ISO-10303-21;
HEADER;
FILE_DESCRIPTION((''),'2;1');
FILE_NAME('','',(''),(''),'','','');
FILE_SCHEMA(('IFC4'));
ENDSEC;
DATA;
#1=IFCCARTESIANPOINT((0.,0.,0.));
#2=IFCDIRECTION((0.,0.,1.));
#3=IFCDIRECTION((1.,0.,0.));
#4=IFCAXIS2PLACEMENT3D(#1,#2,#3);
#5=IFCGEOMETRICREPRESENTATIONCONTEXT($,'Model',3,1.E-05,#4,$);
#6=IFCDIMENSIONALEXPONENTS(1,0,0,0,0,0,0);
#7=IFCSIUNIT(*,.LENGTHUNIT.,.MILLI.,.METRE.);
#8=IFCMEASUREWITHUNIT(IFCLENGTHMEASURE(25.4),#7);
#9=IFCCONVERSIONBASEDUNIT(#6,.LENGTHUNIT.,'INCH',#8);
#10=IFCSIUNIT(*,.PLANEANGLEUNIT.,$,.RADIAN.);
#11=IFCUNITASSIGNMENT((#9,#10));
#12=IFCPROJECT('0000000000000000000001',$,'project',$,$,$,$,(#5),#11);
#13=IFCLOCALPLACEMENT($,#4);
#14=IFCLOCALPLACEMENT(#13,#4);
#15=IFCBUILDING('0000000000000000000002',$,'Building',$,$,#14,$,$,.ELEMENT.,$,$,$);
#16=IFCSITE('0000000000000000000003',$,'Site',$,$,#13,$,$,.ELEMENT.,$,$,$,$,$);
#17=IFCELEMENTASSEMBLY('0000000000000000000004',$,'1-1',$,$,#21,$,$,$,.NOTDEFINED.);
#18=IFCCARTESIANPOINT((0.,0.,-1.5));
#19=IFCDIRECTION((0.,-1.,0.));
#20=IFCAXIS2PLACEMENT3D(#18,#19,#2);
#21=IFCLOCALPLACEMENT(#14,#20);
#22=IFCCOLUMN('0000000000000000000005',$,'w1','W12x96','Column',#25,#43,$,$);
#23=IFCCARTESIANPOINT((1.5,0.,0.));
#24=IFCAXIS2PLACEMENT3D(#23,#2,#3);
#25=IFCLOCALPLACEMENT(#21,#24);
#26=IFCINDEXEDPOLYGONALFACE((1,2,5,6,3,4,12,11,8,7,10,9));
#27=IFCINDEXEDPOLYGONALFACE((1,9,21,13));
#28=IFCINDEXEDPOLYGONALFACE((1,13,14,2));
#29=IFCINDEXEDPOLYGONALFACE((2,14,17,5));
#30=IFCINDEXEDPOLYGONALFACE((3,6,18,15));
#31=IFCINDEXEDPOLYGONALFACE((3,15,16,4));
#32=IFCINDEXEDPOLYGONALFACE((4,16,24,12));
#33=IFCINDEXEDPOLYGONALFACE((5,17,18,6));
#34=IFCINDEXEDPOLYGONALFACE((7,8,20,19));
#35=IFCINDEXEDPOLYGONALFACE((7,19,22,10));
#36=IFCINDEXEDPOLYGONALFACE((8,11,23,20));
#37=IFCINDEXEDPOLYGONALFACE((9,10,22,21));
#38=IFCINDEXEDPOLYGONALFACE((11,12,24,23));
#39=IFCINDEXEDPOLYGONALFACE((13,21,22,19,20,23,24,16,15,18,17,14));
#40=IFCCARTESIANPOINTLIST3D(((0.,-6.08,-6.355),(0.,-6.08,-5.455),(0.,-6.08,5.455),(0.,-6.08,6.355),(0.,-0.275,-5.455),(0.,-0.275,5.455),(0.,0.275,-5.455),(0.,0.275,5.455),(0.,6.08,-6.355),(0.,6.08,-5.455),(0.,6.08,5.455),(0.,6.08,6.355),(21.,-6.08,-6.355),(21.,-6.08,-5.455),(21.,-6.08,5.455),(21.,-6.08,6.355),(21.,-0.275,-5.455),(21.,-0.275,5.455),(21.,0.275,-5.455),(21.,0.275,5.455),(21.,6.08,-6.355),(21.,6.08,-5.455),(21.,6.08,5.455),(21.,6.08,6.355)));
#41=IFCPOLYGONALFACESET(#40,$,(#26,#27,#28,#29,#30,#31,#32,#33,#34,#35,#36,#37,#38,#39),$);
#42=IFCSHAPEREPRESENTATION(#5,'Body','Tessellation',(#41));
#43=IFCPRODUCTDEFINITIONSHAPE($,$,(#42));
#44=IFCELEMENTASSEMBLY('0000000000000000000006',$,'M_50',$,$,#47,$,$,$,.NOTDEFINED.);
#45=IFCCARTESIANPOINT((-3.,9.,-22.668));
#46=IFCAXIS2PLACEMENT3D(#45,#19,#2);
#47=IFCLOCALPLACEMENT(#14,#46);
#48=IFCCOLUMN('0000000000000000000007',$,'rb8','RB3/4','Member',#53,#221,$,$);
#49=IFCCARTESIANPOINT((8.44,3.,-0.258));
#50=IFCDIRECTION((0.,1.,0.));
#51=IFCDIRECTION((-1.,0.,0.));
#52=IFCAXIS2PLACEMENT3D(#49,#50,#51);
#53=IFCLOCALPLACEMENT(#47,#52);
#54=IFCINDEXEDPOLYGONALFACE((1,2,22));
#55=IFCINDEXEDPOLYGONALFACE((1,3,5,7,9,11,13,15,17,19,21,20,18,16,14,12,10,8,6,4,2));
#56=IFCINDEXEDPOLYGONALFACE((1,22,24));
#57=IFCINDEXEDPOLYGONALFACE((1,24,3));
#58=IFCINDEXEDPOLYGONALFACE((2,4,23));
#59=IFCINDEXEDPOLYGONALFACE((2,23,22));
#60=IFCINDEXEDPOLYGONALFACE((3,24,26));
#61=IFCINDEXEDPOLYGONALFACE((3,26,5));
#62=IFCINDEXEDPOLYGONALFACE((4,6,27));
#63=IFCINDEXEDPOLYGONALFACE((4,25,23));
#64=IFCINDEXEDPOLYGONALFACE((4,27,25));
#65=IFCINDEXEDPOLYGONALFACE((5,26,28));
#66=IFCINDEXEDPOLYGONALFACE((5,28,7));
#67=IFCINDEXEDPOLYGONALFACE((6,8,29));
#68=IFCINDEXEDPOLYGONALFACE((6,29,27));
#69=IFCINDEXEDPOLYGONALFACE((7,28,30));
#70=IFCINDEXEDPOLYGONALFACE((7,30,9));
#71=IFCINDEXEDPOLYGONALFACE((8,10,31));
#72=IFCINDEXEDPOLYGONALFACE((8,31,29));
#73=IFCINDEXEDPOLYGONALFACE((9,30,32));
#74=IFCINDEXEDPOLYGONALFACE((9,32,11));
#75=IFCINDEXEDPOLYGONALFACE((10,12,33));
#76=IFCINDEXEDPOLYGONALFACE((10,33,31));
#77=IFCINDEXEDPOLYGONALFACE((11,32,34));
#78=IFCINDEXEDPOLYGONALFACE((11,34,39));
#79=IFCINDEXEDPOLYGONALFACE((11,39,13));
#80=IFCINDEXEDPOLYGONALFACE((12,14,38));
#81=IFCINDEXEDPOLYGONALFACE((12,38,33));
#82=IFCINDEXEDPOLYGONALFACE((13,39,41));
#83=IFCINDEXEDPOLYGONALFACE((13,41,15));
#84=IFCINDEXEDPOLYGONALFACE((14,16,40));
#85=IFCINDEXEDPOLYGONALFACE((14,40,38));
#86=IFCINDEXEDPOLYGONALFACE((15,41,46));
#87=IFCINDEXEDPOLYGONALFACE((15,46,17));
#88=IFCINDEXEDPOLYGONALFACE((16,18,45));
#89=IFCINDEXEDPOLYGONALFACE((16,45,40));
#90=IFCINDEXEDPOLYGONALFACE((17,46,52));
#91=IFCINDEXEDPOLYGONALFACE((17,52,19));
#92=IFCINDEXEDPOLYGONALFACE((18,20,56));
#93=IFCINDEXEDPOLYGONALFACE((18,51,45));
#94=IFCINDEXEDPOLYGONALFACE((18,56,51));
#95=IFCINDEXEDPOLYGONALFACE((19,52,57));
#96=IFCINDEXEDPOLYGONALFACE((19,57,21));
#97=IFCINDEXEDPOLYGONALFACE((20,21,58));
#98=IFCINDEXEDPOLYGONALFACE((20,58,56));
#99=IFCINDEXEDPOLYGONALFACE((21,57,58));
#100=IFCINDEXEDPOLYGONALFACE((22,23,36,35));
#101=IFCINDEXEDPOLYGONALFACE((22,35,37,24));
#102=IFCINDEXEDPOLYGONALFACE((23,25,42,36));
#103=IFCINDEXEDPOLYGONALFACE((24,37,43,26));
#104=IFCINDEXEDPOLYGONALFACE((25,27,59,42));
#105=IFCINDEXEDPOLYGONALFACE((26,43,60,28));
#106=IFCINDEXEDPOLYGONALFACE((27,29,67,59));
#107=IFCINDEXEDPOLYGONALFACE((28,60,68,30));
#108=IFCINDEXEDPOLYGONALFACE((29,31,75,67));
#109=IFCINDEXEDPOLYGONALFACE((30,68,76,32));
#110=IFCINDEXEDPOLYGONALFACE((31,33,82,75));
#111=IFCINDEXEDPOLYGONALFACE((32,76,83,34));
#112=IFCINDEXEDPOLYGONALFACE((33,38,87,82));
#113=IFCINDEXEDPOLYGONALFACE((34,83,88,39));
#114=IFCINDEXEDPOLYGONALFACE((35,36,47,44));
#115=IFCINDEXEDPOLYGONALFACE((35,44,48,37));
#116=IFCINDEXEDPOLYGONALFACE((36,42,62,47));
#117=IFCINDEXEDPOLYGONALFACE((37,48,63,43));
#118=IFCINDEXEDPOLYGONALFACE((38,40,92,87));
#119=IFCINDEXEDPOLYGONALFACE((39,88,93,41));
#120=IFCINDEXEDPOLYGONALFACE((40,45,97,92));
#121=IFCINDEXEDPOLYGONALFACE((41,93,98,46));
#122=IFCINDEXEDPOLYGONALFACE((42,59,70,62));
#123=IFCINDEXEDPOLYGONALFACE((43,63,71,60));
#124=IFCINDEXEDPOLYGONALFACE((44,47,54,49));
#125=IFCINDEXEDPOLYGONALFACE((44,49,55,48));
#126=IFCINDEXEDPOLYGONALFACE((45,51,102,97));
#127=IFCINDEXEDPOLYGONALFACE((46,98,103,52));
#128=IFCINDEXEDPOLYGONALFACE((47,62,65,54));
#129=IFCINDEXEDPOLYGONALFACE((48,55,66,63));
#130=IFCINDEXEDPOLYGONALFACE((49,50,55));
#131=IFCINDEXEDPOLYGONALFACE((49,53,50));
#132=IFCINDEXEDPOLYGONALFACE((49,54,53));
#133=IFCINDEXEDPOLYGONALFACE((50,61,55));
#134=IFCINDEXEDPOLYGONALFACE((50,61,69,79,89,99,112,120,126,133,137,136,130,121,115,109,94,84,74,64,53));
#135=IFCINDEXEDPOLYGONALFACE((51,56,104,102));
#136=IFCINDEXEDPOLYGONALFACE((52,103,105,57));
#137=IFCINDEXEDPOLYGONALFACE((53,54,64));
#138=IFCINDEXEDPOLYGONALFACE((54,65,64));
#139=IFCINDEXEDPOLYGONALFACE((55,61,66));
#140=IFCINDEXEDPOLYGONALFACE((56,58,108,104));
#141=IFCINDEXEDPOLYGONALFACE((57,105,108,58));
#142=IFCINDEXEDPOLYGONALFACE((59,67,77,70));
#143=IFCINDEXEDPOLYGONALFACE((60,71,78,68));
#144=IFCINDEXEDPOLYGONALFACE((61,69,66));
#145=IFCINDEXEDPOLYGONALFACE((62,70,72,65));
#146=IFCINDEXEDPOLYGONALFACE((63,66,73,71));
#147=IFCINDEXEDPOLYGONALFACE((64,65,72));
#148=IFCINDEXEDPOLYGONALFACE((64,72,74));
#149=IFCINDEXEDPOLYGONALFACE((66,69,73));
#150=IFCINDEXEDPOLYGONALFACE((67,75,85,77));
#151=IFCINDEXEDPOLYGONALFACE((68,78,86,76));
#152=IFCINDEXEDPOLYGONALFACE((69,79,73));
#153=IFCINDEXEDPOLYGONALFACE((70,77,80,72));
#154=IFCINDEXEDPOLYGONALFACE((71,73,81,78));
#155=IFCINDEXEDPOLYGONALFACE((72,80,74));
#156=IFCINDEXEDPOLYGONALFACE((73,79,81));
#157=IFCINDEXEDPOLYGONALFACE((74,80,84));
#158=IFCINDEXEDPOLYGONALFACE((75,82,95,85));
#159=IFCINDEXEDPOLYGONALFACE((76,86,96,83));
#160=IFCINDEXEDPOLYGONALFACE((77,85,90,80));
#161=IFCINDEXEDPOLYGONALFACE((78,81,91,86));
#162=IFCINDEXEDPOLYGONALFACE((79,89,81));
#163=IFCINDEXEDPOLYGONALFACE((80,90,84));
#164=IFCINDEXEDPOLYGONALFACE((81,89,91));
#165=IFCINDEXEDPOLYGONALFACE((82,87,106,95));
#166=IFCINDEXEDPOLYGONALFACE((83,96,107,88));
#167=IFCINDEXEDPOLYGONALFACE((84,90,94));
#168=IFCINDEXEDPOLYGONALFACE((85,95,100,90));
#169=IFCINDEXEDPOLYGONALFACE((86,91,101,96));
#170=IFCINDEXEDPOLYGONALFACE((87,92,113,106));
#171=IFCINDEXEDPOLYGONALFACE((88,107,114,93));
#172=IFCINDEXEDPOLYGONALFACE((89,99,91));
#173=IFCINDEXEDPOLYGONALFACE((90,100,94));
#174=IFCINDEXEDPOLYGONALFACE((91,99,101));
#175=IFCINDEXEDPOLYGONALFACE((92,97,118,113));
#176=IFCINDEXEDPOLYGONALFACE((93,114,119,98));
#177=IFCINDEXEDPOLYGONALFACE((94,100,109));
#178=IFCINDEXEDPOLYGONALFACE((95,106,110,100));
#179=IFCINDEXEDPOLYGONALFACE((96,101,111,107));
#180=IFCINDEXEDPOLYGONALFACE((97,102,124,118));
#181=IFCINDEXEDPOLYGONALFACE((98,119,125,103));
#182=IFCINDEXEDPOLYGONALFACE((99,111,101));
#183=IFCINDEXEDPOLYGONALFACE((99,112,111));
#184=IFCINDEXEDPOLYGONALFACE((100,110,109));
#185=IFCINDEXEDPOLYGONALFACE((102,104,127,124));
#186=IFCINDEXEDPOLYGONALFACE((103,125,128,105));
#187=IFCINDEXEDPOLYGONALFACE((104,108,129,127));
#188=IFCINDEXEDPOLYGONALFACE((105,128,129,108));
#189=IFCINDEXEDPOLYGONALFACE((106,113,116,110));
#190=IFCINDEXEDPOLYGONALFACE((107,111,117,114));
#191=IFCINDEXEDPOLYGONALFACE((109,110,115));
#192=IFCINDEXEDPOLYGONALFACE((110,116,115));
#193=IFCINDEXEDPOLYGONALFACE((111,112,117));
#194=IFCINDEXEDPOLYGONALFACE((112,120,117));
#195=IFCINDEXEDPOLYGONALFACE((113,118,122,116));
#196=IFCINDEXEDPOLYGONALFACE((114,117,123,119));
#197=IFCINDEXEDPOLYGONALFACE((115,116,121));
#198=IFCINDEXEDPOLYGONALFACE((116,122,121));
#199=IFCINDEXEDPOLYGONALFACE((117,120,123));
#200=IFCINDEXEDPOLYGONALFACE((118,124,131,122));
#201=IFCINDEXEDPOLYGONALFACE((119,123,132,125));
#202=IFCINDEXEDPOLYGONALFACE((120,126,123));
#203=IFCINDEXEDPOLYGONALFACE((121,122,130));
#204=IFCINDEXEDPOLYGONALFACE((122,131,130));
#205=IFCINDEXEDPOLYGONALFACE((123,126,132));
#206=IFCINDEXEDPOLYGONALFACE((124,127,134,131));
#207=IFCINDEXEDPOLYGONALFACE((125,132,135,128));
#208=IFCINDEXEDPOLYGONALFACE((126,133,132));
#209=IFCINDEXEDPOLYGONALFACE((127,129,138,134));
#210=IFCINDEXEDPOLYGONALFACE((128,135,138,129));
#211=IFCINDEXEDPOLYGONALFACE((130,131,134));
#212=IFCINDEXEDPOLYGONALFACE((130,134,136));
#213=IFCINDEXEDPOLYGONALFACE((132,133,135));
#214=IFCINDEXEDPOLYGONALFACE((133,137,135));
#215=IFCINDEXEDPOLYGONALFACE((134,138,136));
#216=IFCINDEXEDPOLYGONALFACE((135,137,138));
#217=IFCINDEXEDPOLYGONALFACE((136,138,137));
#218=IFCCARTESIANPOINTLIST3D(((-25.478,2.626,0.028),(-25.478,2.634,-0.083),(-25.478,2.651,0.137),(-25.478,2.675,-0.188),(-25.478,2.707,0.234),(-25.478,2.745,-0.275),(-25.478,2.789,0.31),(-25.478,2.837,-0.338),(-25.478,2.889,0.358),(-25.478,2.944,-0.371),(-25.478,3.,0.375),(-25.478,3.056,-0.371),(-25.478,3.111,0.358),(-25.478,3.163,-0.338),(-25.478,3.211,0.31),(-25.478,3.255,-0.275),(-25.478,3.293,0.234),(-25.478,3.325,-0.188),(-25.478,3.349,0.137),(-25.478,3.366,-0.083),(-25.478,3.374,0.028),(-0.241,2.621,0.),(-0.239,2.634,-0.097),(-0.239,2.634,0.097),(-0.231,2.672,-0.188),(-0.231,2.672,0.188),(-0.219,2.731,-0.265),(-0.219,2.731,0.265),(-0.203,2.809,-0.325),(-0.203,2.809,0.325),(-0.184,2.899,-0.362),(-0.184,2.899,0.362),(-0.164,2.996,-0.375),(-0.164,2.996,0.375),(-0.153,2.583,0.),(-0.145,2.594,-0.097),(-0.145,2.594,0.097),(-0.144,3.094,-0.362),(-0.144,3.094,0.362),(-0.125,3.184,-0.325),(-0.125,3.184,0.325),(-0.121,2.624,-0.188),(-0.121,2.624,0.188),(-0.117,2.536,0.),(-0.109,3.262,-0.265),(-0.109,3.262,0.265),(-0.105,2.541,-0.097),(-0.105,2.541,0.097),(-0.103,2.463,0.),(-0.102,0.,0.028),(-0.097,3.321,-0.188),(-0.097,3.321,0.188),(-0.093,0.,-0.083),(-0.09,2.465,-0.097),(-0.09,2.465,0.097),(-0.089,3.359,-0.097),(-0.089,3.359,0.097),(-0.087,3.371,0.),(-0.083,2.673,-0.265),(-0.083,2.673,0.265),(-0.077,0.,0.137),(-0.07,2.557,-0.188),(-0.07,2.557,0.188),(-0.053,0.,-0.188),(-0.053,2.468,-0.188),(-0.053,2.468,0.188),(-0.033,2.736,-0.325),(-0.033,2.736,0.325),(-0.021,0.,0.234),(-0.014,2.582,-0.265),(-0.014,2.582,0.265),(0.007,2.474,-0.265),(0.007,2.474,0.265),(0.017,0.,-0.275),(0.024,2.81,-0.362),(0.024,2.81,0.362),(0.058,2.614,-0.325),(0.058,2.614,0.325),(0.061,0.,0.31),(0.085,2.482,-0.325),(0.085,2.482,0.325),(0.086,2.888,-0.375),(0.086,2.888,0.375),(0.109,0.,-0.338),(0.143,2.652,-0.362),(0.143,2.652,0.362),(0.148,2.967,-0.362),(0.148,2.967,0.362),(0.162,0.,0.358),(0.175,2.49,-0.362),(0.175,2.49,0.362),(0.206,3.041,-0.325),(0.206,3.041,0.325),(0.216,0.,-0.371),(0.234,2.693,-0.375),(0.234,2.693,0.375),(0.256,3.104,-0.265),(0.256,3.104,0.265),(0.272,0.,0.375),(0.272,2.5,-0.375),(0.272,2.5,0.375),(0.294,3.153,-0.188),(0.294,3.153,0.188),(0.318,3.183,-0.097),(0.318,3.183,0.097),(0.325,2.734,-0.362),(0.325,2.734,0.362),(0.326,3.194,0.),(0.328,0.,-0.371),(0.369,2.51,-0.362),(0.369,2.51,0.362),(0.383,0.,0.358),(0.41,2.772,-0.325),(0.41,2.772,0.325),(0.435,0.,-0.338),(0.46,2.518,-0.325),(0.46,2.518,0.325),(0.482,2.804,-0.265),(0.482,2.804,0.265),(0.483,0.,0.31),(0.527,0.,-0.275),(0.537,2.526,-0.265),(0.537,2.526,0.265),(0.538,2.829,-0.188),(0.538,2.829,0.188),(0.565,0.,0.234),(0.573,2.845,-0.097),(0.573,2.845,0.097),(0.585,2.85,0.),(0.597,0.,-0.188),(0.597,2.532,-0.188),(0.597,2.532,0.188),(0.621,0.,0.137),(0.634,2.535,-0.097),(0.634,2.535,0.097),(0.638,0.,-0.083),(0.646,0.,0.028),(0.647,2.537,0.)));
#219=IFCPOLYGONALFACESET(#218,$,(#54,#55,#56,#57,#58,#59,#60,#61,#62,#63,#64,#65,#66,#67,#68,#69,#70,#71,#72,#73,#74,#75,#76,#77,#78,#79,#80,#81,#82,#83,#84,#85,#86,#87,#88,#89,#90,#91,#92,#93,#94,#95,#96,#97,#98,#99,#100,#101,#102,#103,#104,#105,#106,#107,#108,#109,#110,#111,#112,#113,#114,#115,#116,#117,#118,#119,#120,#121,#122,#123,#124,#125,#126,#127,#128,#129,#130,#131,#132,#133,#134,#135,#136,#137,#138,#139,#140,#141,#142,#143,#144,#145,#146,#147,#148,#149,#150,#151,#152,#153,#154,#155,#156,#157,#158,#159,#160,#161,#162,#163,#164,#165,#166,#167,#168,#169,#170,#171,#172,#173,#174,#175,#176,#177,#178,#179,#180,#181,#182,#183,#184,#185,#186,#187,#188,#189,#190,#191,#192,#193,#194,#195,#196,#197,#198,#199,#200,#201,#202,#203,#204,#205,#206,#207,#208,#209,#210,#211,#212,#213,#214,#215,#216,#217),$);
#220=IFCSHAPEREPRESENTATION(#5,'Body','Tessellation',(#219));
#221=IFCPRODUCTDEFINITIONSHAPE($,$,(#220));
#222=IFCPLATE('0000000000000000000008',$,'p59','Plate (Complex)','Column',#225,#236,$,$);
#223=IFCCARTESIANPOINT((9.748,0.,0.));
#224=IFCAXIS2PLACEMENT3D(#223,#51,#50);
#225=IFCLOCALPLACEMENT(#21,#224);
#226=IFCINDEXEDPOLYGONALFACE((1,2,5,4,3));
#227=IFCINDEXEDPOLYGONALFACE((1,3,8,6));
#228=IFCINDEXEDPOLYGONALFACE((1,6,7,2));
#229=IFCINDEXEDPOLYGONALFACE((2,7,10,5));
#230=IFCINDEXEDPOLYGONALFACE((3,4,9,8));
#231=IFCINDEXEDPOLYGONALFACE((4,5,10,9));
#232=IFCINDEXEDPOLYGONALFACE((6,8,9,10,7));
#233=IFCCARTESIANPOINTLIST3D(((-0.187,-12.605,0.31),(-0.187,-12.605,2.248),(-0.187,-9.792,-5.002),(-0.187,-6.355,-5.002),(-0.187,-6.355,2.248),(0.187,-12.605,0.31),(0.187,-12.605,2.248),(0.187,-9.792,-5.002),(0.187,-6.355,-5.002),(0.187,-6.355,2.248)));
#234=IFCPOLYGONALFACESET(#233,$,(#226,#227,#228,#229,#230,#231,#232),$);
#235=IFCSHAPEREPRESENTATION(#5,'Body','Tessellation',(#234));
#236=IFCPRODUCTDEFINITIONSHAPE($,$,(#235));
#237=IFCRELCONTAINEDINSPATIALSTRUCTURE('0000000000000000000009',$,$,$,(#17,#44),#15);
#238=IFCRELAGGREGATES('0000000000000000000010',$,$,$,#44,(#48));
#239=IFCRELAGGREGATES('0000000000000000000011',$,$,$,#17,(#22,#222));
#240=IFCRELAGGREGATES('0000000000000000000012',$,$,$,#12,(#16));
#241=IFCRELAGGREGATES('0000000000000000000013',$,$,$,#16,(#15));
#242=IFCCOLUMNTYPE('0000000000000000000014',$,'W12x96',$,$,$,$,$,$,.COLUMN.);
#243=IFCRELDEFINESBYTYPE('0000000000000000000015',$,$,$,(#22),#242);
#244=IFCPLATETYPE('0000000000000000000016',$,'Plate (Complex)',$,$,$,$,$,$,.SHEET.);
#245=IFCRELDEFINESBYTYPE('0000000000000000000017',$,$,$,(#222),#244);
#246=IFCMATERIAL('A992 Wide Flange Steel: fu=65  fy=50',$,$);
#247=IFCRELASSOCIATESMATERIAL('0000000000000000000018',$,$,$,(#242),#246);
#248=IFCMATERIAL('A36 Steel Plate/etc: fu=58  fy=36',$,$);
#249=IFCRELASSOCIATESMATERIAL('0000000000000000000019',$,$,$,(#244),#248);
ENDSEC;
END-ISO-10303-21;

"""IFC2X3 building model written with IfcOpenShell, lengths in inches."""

from ifc_helpers import new_model, entity, si_unit, converted_unit, frame, origin_with_axes, origin_2d_with_axis, place, context, project, spatial, polyline, i_section, outline, extrude, source, transform, mapped, material, type_object, type_shapes, element, aggregate, save


model = new_model("IFC2X3")

# Units and contexts
model_context = context("Model", 3, precision=1e-05, world=origin_with_axes())
ifc_project = project(units=[converted_unit("LENGTHUNIT", "INCH", entity("IfcLengthMeasure", 25.4), si_unit("LENGTHUNIT", "METRE", prefix="MILLI"), dimensions=[1, 0, 0, 0, 0, 0, 0]), si_unit("PLANEANGLEUNIT", "RADIAN")], contexts=[model_context])

# Site, building
site_placement = place(None, origin_with_axes())
site = spatial("IfcSite", under=ifc_project, at=site_placement, Name="Site", CompositionType="ELEMENT")
building_placement = place(site_placement, origin_with_axes())
building = spatial("IfcBuilding", under=site, at=building_placement, Name="Building", CompositionType="ELEMENT")

# Element assemblies, columns
assembly_1_placement = place(building_placement, frame((0.0, 0.0, -1.5), z_axis=(0.0, -1.0, 0.0), x_axis=(0.0, 0.0, 1.0)))
assembly_1 = element("IfcElementAssembly", 1, at=assembly_1_placement, inside=building, Name="1-1", PredefinedType="NOTDEFINED")
ifc_material_1 = material(Name="A992 Wide Flange Steel: fu=65  fy=50")
column_type_1 = type_object("IfcColumnType", Name="W12x96", PredefinedType="COLUMN", material=ifc_material_1)
shared_shape_1 = source(origin_with_axes(), model_context, "Body", "SweptSolid", [
    extrude(i_section(OverallWidth=12.16, OverallDepth=12.71, WebThickness=0.55, FlangeThickness=0.9, at=origin_2d_with_axis()), frame((0.0, 0.0, 0.0), z_axis=(1.0, 0.0, 0.0), x_axis=(0.0, 1.0, 0.0)), (0.0, 0.0, 1.0), 21.0),
])
type_shapes(column_type_1, [shared_shape_1])
column_1_placement = place(assembly_1_placement, frame((1.5, 0.0, 0.0), z_axis=(0.0, 0.0, 1.0), x_axis=(1.0, 0.0, 0.0)))
column_1 = element("IfcColumn", 2, at=column_1_placement, type_object=column_type_1, Name="w1", Description="W12x96", ObjectType="Column", context=model_context, shape_type="MappedRepresentation", body=[
    mapped(shared_shape_1, transform((0.0, 0.0, 0.0), scale=1.0)),
])
assembly_2_placement = place(building_placement, frame((-3.0, 9.0, -22.668), z_axis=(0.0, -1.0, 0.0), x_axis=(0.0, 0.0, 1.0)))
assembly_2 = element("IfcElementAssembly", 3, at=assembly_2_placement, inside=building, Name="M_50", PredefinedType="NOTDEFINED")
column_2_placement = place(assembly_2_placement, frame((8.44, 3.0, -0.258), z_axis=(0.0, 1.0, 0.0), x_axis=(-1.0, 0.0, 0.0)))
cartesian_point_1 = entity("IfcCartesianPoint", [0.0, 0.0, 0.0])
ifc_direction_1 = entity("IfcDirection", [0.0, 0.0, 1.0])
ifc_direction_2 = entity("IfcDirection", [1.0, 0.0, 0.0])
column_2 = element("IfcColumn", 4, at=column_2_placement, Name="rb8", Description="RB3/4", ObjectType="Member", context=model_context, shape_type="SweptSolid", body=[
    entity("IfcSurfaceCurveSweptAreaSolid", entity("IfcCircleProfileDef", "AREA", None, entity("IfcAxis2Placement2D", entity("IfcCartesianPoint", [0.0, 0.0]), entity("IfcDirection", [1.0, 0.0])), 0.375), entity("IfcAxis2Placement3D", cartesian_point_1, ifc_direction_1, ifc_direction_2), entity("IfcPolyline", [entity("IfcCartesianPoint", [0.272, 0.0]), entity("IfcCartesianPoint", [0.272, 2.5]), entity("IfcCartesianPoint", [0.234, 2.693]), entity("IfcCartesianPoint", [0.086, 2.888]), entity("IfcCartesianPoint", [-0.164, 2.996]), entity("IfcCartesianPoint", [-25.478, 3.0])]), 0.0, 1.0, entity("IfcPlane", entity("IfcAxis2Placement3D", cartesian_point_1, ifc_direction_1, ifc_direction_2))),
])

# Shared definitions
ifc_material_2 = material(Name="A36 Steel Plate/etc: fu=58  fy=36")

# Plate
aggregate(assembly_2, [column_2])
plate_type_1 = type_object("IfcPlateType", Name="Plate (Complex)", PredefinedType="SHEET", material=ifc_material_2)
shared_shape_2 = source(origin_with_axes(), model_context, "Body", "SweptSolid", [
    extrude(outline(polyline([(-6.355, -5.002), (-9.793, -5.002), (-12.605, 0.31), (-12.605, 2.248), (-6.355, 2.248), (-6.355, -5.002)])), frame((-0.188, 0.0, 0.0), z_axis=(1.0, 0.0, 0.0), x_axis=(0.0, 1.0, 0.0)), (0.0, 0.0, 1.0), 0.375),
])
type_shapes(plate_type_1, [shared_shape_2])
plate_1_placement = place(assembly_1_placement, frame((9.748, 0.0, 0.0), z_axis=(-1.0, 0.0, 0.0), x_axis=(0.0, 1.0, 0.0)))
plate_1 = element("IfcPlate", 5, at=plate_1_placement, type_object=plate_type_1, Name="p59", Description="Plate (Complex)", ObjectType="Column", context=model_context, shape_type="MappedRepresentation", body=[
    mapped(shared_shape_2, transform((0.0, 0.0, 0.0), scale=1.0)),
])
aggregate(assembly_1, [column_1, plate_1])

save(model, "model.ifc")
